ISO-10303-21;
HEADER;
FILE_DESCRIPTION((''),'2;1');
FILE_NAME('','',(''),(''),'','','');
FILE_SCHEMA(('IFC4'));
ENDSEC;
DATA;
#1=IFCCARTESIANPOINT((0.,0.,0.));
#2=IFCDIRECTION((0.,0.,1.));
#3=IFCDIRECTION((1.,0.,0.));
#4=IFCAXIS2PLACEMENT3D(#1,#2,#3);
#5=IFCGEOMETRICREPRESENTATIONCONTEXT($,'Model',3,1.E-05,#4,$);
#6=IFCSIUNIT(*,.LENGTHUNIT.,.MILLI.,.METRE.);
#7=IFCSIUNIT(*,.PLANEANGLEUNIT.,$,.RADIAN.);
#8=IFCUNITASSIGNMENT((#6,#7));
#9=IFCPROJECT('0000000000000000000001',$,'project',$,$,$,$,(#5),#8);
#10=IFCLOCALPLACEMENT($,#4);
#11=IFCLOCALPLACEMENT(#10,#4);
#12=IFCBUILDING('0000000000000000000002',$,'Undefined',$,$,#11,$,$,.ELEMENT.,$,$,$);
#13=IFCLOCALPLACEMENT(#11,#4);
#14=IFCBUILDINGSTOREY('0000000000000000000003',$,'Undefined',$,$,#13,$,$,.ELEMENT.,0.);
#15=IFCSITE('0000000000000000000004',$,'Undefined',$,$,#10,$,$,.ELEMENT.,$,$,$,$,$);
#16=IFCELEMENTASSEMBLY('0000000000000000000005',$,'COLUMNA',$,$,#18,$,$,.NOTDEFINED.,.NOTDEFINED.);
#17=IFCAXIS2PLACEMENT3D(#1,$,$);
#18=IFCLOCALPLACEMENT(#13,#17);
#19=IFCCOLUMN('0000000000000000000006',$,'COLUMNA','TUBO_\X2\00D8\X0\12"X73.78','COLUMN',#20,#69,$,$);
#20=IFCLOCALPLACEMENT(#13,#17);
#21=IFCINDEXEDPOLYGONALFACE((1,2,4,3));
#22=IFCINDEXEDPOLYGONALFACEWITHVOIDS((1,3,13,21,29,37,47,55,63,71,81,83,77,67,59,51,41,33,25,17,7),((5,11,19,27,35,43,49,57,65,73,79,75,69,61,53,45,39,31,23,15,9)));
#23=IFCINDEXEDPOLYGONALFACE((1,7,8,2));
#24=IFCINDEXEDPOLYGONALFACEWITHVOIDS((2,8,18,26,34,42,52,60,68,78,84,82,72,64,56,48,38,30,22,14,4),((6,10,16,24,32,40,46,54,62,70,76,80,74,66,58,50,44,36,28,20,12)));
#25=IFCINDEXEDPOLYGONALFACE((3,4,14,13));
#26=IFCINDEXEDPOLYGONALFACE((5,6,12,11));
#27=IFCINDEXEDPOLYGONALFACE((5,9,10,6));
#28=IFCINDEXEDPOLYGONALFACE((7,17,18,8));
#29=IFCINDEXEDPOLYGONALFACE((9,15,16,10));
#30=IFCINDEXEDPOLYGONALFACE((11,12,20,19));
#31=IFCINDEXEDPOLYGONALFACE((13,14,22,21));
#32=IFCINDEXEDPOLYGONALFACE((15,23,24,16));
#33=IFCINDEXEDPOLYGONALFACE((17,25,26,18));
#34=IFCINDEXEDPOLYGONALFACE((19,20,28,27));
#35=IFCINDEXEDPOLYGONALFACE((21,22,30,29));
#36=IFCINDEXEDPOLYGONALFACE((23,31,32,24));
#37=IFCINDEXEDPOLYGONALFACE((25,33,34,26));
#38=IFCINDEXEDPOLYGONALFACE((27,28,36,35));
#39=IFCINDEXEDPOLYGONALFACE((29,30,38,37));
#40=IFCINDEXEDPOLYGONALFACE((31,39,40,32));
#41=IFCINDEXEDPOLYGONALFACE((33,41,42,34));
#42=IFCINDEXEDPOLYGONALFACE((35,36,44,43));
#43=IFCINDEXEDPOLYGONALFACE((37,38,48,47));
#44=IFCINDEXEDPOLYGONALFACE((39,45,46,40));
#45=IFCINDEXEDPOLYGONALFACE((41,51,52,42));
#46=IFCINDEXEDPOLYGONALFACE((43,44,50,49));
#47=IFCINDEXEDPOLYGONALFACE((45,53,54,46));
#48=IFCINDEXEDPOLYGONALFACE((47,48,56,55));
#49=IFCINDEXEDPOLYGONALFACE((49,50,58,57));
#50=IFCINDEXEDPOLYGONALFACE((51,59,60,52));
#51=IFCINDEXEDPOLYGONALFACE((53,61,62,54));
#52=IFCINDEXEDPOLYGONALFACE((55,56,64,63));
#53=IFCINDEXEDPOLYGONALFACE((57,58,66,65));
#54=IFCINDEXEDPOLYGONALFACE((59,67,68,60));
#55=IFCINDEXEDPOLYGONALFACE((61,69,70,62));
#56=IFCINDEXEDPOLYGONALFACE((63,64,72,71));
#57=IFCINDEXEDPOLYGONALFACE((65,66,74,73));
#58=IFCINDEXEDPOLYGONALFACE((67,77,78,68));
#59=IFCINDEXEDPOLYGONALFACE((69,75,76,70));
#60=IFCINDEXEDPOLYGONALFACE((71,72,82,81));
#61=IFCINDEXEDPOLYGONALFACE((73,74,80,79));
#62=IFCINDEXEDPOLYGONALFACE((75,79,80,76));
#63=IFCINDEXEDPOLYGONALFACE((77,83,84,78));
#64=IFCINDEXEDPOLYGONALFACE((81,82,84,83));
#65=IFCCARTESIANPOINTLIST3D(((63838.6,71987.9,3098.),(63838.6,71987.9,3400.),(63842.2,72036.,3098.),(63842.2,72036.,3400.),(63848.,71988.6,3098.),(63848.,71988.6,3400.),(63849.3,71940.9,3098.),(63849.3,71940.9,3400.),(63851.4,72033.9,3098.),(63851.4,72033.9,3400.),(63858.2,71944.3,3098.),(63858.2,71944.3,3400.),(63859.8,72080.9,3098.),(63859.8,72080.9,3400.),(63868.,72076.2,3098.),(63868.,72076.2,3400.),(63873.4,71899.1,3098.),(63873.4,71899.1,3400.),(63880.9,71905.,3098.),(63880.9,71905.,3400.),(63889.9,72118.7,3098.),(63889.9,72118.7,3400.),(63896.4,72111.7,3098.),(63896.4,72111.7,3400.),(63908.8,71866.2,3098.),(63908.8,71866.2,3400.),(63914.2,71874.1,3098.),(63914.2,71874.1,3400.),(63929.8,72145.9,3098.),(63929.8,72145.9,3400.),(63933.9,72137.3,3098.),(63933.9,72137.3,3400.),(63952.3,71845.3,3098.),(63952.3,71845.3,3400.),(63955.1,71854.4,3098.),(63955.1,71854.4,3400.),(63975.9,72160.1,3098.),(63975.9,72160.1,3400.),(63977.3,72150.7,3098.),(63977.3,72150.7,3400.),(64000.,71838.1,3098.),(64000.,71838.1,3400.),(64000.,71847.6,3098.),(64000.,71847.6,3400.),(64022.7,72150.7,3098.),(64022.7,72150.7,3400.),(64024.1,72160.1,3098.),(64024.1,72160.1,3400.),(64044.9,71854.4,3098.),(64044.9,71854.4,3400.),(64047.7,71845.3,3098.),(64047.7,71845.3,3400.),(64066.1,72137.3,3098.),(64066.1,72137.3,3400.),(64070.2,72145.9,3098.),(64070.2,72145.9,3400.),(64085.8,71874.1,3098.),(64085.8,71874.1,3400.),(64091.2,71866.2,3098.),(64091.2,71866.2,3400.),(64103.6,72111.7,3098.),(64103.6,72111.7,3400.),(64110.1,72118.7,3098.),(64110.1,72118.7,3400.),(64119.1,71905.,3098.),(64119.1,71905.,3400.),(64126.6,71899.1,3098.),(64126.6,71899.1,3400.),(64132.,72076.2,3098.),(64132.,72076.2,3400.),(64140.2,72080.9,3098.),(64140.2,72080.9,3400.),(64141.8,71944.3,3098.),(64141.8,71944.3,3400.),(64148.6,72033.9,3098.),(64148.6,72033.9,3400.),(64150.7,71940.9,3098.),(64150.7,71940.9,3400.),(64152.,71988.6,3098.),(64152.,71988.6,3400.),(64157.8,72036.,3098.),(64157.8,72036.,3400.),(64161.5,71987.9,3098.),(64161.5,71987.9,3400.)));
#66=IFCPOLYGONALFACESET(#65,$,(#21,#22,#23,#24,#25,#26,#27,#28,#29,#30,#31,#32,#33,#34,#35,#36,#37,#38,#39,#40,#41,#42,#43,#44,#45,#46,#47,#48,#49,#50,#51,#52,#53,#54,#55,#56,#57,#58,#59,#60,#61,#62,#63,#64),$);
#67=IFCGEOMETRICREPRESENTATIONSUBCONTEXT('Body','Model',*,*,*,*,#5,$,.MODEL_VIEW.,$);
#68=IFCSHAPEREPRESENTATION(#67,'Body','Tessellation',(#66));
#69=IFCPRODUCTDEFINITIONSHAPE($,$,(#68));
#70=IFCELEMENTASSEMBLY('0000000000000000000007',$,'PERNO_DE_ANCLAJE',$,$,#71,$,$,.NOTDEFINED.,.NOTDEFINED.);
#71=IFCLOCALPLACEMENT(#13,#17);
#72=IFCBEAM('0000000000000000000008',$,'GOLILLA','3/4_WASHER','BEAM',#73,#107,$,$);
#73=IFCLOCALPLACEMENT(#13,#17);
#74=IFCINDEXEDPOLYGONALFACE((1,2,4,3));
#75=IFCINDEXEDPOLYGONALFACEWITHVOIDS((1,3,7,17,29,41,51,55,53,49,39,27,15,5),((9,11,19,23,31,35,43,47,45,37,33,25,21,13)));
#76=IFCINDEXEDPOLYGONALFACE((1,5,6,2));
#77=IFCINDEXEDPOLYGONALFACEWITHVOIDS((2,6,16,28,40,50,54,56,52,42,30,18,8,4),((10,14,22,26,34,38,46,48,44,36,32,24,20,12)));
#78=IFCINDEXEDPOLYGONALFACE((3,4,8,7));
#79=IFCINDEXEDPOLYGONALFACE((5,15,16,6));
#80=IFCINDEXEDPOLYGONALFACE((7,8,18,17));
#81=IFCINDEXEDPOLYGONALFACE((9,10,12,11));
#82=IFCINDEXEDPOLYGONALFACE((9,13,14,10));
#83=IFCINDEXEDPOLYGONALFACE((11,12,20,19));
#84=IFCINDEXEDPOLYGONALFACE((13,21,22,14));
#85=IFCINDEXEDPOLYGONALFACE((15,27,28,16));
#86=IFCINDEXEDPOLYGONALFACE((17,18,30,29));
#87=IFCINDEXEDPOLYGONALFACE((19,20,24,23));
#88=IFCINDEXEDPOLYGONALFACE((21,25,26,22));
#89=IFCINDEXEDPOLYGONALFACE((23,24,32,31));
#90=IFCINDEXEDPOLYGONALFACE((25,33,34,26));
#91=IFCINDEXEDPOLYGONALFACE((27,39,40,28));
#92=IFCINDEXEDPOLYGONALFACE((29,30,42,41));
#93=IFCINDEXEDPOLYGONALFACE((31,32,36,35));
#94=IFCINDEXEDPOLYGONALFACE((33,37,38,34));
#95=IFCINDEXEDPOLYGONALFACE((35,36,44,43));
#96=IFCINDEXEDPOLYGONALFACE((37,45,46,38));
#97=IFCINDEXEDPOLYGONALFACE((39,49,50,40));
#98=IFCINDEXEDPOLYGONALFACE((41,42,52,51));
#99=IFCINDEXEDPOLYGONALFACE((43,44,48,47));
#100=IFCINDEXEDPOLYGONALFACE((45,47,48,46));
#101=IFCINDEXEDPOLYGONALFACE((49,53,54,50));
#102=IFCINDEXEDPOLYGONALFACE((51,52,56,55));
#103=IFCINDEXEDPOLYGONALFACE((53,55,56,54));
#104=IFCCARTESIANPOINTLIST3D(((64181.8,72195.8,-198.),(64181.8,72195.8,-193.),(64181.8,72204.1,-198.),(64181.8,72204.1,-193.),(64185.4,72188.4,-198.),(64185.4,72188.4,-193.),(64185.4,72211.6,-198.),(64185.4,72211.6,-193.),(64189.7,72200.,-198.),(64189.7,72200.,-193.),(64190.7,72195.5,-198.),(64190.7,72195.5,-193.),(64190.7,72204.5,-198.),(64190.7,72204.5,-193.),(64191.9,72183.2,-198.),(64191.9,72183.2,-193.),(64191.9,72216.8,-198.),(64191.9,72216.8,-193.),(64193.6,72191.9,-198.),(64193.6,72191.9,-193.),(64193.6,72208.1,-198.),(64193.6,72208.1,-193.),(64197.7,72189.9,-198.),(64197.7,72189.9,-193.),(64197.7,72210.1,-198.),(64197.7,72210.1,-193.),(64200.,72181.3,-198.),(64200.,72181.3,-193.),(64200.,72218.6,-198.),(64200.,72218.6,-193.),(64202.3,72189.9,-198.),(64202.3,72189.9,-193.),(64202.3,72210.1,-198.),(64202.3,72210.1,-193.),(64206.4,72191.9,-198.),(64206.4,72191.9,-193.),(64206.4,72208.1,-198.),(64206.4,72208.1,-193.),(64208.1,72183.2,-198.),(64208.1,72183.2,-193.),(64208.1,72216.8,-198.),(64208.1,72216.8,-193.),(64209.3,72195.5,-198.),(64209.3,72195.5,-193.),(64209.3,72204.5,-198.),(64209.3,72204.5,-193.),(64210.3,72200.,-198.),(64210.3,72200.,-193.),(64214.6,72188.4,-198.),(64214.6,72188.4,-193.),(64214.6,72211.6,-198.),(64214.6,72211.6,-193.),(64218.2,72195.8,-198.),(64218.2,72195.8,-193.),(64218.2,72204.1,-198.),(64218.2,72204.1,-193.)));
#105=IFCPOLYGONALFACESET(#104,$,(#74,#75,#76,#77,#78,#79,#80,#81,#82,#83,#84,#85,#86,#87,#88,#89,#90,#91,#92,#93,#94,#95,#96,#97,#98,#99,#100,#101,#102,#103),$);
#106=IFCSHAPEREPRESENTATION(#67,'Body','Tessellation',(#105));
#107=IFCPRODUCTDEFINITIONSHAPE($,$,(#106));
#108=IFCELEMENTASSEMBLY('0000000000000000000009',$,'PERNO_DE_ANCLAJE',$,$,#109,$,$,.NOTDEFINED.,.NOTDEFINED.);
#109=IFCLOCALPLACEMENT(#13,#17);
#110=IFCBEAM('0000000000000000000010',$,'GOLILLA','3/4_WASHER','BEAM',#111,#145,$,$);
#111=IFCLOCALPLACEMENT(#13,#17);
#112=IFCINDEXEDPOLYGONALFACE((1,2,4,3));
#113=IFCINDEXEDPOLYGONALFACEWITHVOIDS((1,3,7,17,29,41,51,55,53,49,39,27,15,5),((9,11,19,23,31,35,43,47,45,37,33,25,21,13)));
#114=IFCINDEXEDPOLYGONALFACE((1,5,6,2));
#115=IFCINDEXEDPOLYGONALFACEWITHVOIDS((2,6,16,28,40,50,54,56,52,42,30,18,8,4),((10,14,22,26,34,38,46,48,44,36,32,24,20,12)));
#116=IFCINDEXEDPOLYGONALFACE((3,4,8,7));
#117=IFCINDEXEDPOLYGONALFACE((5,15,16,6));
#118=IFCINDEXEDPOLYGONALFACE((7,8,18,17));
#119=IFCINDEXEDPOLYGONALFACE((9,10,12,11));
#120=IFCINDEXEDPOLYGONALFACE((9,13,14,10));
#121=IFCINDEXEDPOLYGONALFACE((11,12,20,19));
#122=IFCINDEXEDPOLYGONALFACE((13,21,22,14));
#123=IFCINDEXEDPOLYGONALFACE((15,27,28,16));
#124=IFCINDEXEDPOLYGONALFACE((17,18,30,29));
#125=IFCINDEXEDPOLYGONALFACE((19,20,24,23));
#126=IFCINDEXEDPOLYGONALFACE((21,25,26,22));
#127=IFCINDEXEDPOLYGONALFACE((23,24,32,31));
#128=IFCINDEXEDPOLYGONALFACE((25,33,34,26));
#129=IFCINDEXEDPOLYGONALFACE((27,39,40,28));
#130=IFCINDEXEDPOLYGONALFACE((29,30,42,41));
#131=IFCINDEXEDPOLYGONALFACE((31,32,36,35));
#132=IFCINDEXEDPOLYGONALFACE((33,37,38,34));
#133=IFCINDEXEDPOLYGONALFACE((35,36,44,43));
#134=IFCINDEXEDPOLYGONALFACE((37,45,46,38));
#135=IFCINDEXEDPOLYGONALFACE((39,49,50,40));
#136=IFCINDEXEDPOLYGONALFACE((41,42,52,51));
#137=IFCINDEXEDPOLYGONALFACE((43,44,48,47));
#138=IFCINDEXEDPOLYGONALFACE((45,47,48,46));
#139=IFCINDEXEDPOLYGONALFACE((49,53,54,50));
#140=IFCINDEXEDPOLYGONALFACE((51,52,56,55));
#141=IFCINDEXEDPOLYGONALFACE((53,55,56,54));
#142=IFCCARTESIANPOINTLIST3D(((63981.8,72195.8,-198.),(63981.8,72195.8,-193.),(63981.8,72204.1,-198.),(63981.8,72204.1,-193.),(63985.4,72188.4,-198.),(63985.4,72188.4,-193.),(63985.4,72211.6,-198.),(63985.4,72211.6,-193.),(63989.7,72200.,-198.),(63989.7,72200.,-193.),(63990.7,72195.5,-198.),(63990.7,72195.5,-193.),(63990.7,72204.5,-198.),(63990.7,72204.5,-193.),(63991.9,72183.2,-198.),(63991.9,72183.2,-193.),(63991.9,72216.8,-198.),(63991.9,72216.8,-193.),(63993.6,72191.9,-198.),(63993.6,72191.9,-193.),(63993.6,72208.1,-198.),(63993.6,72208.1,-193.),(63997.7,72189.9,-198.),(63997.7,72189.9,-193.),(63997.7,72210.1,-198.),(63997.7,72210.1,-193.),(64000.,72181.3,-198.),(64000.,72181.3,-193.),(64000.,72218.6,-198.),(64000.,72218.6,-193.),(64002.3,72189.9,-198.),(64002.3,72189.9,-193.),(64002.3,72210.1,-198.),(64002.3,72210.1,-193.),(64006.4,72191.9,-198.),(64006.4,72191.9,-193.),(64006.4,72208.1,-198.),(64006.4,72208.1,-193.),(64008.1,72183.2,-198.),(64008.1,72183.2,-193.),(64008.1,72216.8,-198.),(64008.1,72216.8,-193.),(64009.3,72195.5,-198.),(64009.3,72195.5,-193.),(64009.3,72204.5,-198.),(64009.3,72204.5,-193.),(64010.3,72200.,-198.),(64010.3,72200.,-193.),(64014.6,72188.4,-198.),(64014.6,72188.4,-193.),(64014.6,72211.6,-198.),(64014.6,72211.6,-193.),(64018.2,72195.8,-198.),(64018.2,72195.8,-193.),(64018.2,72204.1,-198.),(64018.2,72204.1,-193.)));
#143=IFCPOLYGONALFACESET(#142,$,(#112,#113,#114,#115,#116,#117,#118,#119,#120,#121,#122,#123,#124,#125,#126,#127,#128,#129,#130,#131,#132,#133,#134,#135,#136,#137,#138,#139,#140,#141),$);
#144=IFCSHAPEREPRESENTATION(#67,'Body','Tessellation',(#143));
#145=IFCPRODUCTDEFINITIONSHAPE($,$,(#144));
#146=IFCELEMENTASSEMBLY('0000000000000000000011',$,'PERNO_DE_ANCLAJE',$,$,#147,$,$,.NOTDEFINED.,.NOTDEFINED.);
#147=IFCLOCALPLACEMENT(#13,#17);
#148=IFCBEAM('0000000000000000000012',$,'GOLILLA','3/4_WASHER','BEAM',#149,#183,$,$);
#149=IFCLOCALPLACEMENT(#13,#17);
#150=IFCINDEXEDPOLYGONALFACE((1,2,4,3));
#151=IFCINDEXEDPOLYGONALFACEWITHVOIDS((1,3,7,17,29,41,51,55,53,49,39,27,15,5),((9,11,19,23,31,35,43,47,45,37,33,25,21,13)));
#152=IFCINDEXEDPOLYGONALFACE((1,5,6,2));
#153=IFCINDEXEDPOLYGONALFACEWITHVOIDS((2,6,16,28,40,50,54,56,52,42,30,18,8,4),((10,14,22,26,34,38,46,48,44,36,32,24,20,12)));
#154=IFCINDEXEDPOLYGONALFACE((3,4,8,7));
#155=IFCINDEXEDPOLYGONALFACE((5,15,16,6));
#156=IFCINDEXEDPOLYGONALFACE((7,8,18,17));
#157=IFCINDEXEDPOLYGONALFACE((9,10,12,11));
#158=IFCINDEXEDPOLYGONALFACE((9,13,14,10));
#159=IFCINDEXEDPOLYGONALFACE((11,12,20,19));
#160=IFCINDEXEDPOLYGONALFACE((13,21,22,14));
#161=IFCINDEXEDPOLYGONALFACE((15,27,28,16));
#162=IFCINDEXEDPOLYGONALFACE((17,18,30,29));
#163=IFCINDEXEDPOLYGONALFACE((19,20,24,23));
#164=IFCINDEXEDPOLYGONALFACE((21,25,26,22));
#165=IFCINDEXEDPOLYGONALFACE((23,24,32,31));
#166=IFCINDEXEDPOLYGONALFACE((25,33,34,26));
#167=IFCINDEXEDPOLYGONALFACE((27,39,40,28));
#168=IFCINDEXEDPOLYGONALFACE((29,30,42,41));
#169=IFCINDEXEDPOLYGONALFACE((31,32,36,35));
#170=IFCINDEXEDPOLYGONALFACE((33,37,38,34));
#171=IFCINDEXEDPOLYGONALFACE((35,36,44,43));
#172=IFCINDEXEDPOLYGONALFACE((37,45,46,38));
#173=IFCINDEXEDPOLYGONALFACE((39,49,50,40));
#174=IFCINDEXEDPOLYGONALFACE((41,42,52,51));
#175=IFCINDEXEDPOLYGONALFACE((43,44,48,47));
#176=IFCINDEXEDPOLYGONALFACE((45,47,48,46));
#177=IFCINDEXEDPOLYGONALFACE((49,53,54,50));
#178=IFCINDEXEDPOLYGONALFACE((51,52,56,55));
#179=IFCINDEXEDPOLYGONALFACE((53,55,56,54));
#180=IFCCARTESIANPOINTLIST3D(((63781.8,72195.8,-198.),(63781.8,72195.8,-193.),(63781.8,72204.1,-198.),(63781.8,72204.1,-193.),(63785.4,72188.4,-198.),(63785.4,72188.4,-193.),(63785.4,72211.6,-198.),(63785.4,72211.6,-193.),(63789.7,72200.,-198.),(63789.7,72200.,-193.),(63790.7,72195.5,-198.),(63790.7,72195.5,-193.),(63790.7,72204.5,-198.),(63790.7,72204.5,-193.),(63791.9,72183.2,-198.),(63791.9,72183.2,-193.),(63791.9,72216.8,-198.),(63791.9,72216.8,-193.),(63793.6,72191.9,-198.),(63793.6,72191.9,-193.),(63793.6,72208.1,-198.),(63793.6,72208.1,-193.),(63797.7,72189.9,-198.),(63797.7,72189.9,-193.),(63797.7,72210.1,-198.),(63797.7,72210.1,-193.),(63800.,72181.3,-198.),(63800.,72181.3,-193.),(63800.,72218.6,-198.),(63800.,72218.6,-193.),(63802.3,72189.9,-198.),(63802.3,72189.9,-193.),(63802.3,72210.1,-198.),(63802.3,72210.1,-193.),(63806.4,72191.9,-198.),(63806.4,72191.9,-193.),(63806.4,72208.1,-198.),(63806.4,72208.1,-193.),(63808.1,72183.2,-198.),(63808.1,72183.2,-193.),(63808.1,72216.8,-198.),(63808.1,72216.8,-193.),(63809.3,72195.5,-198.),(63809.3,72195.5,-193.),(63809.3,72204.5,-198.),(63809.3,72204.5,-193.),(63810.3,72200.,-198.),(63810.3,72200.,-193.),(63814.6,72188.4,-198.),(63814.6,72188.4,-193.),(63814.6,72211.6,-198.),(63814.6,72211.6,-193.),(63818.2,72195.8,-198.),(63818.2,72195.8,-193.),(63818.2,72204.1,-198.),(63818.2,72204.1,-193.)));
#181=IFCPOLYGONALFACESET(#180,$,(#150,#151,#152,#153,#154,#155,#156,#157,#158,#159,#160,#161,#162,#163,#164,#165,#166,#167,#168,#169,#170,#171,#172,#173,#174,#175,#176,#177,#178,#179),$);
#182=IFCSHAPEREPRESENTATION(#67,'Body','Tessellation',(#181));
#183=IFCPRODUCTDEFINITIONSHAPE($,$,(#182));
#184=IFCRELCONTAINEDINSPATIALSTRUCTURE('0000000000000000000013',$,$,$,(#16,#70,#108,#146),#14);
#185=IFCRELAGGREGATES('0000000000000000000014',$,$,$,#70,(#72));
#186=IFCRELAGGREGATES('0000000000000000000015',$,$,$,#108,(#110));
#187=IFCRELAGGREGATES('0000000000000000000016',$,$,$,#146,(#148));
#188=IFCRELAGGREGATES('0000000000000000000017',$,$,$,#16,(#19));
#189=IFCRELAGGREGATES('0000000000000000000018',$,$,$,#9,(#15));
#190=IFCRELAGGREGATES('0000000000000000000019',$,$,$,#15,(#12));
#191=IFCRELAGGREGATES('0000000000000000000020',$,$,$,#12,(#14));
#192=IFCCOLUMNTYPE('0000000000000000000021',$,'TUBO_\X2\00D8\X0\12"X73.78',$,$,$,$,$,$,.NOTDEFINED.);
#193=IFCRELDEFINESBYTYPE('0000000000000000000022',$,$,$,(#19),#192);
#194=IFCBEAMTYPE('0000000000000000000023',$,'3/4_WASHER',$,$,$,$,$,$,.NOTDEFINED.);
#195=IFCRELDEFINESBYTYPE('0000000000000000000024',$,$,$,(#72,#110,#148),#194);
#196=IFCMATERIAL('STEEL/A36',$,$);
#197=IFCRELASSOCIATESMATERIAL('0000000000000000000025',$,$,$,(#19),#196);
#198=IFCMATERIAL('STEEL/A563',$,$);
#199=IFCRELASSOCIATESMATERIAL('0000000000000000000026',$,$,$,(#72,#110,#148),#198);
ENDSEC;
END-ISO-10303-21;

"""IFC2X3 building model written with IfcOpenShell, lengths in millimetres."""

from ifc_helpers import new_model, si_unit, frame, origin_with_axes, origin_2d_with_axis, place, context, subcontext, project, spatial, polyline, hollow_circle, outline, extrude, material, type_object, element, aggregate, save


model = new_model("IFC2X3")

# Units and contexts
model_context = context("Model", 3, precision=1e-05, world=origin_with_axes())
body_context = subcontext(model_context, "Body", "Model", "MODEL_VIEW")
ifc_project = project(units=[si_unit("LENGTHUNIT", "METRE", prefix="MILLI"), si_unit("PLANEANGLEUNIT", "RADIAN")], contexts=[model_context])

# Site, building, storey
site_placement = place(None, origin_with_axes())
site = spatial("IfcSite", under=ifc_project, at=site_placement, Name="Undefined", CompositionType="ELEMENT")
building_placement = place(site_placement, origin_with_axes())
building = spatial("IfcBuilding", under=site, at=building_placement, Name="Undefined", CompositionType="ELEMENT")
storey_placement = place(building_placement, origin_with_axes())
storey = spatial("IfcBuildingStorey", under=building, at=storey_placement, Name="Undefined", CompositionType="ELEMENT", Elevation=0.0)

# Element assembly, column
assembly_1_placement = place(storey_placement, origin_with_axes())
assembly_1 = element("IfcElementAssembly", 1, at=assembly_1_placement, inside=storey, Name="COLUMNA", AssemblyPlace="NOTDEFINED", PredefinedType="NOTDEFINED")
ifc_material_1 = material(Name="STEEL/A36")
column_type = type_object("IfcColumnType", Name="TUBO_Ø12\"X73.78", PredefinedType="NOTDEFINED")
column_placement = place(assembly_1_placement, frame((64000.0, 72000.0, 3098.0), z_axis=(0.0, 0.0, 1.0), x_axis=(-1.0, 0.0, 0.0)))
column = element("IfcColumn", 2, at=column_placement, type_object=column_type, material=ifc_material_1, Name="COLUMNA", Description="TUBO_Ø12\"X73.78", ObjectType="COLUMN", context=body_context, shape_type="SweptSolid", body=[
    extrude(hollow_circle(Radius=161.9, WallThickness=9.5, at=origin_2d_with_axis()), frame((0.0, 0.0, 302.0), z_axis=(0.0, 0.0, -1.0), x_axis=(0.0, 1.0, 0.0)), (0.0, 0.0, 1.0), 302.0),
])

# Element assemblies, beams
assembly_2_placement = place(storey_placement, origin_with_axes())
assembly_2 = element("IfcElementAssembly", 3, at=assembly_2_placement, inside=storey, Name="PERNO_DE_ANCLAJE", AssemblyPlace="NOTDEFINED", PredefinedType="NOTDEFINED")
ifc_material_2 = material(Name="STEEL/A563")
beam_type_1 = type_object("IfcBeamType", Name="3/4_WASHER", PredefinedType="NOTDEFINED")
beam_1_placement = place(assembly_2_placement, frame((64200.0, 72200.0, -193.0), z_axis=(1.0, 0.0, 0.0), x_axis=(0.0, 0.00008, -1.0)))
beam_1 = element("IfcBeam", 4, at=beam_1_placement, type_object=beam_type_1, material=ifc_material_2, Name="GOLILLA", Description="3/4_WASHER", ObjectType="BEAM", context=body_context, shape_type="SweptSolid", body=[
    extrude(outline(polyline([(-16.8, 8.1), (-11.6, 14.6), (-4.2, 18.2), (4.2, 18.2), (11.6, 14.6), (16.8, 8.1), (18.6, 0.0), (16.8, -8.1), (11.6, -14.6), (4.2, -18.2), (-4.2, -18.2), (-11.6, -14.6), (-16.8, -8.1), (-18.6, 0.0), (-16.8, 8.1)]), holes=[polyline([(8.1, 6.4), (4.5, 9.3), (0.0, 10.3), (-4.5, 9.3), (-8.1, 6.4), (-10.1, 2.3), (-10.1, -2.3), (-8.1, -6.4), (-4.5, -9.3), (0.0, -10.3), (4.5, -9.3), (8.1, -6.4), (10.1, -2.3), (10.1, 2.3), (8.1, 6.4)])]), frame((5.0, 0.0, 0.0), z_axis=(-1.0, 0.0, 0.0), x_axis=(0.0, -1.0, 0.0)), (0.0, 0.0, 1.0), 5.0),
])
assembly_3_placement = place(storey_placement, origin_with_axes())
assembly_3 = element("IfcElementAssembly", 5, at=assembly_3_placement, inside=storey, Name="PERNO_DE_ANCLAJE", AssemblyPlace="NOTDEFINED", PredefinedType="NOTDEFINED")
beam_2_placement = place(assembly_3_placement, frame((64000.0, 72200.0, -193.0), z_axis=(1.0, 0.0, 0.0), x_axis=(0.0, 0.00008, -1.0)))
beam_2 = element("IfcBeam", 6, at=beam_2_placement, type_object=beam_type_1, material=ifc_material_2, Name="GOLILLA", Description="3/4_WASHER", ObjectType="BEAM", context=body_context, shape_type="SweptSolid", body=[
    extrude(outline(polyline([(-16.8, 8.1), (-11.6, 14.6), (-4.2, 18.2), (4.2, 18.2), (11.6, 14.6), (16.8, 8.1), (18.6, 0.0), (16.8, -8.1), (11.6, -14.6), (4.2, -18.2), (-4.2, -18.2), (-11.6, -14.6), (-16.8, -8.1), (-18.6, 0.0), (-16.8, 8.1)]), holes=[polyline([(8.1, 6.4), (4.5, 9.3), (0.0, 10.3), (-4.5, 9.3), (-8.1, 6.4), (-10.1, 2.3), (-10.1, -2.3), (-8.1, -6.4), (-4.5, -9.3), (0.0, -10.3), (4.5, -9.3), (8.1, -6.4), (10.1, -2.3), (10.1, 2.3), (8.1, 6.4)])]), frame((5.0, 0.0, 0.0), z_axis=(-1.0, 0.0, 0.0), x_axis=(0.0, -1.0, 0.0)), (0.0, 0.0, 1.0), 5.0),
])
assembly_4_placement = place(storey_placement, origin_with_axes())
assembly_4 = element("IfcElementAssembly", 7, at=assembly_4_placement, inside=storey, Name="PERNO_DE_ANCLAJE", AssemblyPlace="NOTDEFINED", PredefinedType="NOTDEFINED")
beam_3_placement = place(assembly_4_placement, frame((63800.0, 72200.0, -193.0), z_axis=(1.0, 0.0, 0.0), x_axis=(0.0, 0.00008, -1.0)))
beam_3 = element("IfcBeam", 8, at=beam_3_placement, type_object=beam_type_1, material=ifc_material_2, Name="GOLILLA", Description="3/4_WASHER", ObjectType="BEAM", context=body_context, shape_type="SweptSolid", body=[
    extrude(outline(polyline([(-16.8, 8.1), (-11.6, 14.6), (-4.2, 18.2), (4.2, 18.2), (11.6, 14.6), (16.8, 8.1), (18.6, 0.0), (16.8, -8.1), (11.6, -14.6), (4.2, -18.2), (-4.2, -18.2), (-11.6, -14.6), (-16.8, -8.1), (-18.6, 0.0), (-16.8, 8.1)]), holes=[polyline([(8.1, 6.4), (4.5, 9.3), (0.0, 10.3), (-4.5, 9.3), (-8.1, 6.4), (-10.1, 2.3), (-10.1, -2.3), (-8.1, -6.4), (-4.5, -9.3), (0.0, -10.3), (4.5, -9.3), (8.1, -6.4), (10.1, -2.3), (10.1, 2.3), (8.1, 6.4)])]), frame((5.0, 0.0, 0.0), z_axis=(-1.0, 0.0, 0.0), x_axis=(0.0, -1.0, 0.0)), (0.0, 0.0, 1.0), 5.0),
])

aggregate(assembly_2, [beam_1])
aggregate(assembly_3, [beam_2])
aggregate(assembly_4, [beam_3])

aggregate(assembly_1, [column])

save(model, "model.ifc")
